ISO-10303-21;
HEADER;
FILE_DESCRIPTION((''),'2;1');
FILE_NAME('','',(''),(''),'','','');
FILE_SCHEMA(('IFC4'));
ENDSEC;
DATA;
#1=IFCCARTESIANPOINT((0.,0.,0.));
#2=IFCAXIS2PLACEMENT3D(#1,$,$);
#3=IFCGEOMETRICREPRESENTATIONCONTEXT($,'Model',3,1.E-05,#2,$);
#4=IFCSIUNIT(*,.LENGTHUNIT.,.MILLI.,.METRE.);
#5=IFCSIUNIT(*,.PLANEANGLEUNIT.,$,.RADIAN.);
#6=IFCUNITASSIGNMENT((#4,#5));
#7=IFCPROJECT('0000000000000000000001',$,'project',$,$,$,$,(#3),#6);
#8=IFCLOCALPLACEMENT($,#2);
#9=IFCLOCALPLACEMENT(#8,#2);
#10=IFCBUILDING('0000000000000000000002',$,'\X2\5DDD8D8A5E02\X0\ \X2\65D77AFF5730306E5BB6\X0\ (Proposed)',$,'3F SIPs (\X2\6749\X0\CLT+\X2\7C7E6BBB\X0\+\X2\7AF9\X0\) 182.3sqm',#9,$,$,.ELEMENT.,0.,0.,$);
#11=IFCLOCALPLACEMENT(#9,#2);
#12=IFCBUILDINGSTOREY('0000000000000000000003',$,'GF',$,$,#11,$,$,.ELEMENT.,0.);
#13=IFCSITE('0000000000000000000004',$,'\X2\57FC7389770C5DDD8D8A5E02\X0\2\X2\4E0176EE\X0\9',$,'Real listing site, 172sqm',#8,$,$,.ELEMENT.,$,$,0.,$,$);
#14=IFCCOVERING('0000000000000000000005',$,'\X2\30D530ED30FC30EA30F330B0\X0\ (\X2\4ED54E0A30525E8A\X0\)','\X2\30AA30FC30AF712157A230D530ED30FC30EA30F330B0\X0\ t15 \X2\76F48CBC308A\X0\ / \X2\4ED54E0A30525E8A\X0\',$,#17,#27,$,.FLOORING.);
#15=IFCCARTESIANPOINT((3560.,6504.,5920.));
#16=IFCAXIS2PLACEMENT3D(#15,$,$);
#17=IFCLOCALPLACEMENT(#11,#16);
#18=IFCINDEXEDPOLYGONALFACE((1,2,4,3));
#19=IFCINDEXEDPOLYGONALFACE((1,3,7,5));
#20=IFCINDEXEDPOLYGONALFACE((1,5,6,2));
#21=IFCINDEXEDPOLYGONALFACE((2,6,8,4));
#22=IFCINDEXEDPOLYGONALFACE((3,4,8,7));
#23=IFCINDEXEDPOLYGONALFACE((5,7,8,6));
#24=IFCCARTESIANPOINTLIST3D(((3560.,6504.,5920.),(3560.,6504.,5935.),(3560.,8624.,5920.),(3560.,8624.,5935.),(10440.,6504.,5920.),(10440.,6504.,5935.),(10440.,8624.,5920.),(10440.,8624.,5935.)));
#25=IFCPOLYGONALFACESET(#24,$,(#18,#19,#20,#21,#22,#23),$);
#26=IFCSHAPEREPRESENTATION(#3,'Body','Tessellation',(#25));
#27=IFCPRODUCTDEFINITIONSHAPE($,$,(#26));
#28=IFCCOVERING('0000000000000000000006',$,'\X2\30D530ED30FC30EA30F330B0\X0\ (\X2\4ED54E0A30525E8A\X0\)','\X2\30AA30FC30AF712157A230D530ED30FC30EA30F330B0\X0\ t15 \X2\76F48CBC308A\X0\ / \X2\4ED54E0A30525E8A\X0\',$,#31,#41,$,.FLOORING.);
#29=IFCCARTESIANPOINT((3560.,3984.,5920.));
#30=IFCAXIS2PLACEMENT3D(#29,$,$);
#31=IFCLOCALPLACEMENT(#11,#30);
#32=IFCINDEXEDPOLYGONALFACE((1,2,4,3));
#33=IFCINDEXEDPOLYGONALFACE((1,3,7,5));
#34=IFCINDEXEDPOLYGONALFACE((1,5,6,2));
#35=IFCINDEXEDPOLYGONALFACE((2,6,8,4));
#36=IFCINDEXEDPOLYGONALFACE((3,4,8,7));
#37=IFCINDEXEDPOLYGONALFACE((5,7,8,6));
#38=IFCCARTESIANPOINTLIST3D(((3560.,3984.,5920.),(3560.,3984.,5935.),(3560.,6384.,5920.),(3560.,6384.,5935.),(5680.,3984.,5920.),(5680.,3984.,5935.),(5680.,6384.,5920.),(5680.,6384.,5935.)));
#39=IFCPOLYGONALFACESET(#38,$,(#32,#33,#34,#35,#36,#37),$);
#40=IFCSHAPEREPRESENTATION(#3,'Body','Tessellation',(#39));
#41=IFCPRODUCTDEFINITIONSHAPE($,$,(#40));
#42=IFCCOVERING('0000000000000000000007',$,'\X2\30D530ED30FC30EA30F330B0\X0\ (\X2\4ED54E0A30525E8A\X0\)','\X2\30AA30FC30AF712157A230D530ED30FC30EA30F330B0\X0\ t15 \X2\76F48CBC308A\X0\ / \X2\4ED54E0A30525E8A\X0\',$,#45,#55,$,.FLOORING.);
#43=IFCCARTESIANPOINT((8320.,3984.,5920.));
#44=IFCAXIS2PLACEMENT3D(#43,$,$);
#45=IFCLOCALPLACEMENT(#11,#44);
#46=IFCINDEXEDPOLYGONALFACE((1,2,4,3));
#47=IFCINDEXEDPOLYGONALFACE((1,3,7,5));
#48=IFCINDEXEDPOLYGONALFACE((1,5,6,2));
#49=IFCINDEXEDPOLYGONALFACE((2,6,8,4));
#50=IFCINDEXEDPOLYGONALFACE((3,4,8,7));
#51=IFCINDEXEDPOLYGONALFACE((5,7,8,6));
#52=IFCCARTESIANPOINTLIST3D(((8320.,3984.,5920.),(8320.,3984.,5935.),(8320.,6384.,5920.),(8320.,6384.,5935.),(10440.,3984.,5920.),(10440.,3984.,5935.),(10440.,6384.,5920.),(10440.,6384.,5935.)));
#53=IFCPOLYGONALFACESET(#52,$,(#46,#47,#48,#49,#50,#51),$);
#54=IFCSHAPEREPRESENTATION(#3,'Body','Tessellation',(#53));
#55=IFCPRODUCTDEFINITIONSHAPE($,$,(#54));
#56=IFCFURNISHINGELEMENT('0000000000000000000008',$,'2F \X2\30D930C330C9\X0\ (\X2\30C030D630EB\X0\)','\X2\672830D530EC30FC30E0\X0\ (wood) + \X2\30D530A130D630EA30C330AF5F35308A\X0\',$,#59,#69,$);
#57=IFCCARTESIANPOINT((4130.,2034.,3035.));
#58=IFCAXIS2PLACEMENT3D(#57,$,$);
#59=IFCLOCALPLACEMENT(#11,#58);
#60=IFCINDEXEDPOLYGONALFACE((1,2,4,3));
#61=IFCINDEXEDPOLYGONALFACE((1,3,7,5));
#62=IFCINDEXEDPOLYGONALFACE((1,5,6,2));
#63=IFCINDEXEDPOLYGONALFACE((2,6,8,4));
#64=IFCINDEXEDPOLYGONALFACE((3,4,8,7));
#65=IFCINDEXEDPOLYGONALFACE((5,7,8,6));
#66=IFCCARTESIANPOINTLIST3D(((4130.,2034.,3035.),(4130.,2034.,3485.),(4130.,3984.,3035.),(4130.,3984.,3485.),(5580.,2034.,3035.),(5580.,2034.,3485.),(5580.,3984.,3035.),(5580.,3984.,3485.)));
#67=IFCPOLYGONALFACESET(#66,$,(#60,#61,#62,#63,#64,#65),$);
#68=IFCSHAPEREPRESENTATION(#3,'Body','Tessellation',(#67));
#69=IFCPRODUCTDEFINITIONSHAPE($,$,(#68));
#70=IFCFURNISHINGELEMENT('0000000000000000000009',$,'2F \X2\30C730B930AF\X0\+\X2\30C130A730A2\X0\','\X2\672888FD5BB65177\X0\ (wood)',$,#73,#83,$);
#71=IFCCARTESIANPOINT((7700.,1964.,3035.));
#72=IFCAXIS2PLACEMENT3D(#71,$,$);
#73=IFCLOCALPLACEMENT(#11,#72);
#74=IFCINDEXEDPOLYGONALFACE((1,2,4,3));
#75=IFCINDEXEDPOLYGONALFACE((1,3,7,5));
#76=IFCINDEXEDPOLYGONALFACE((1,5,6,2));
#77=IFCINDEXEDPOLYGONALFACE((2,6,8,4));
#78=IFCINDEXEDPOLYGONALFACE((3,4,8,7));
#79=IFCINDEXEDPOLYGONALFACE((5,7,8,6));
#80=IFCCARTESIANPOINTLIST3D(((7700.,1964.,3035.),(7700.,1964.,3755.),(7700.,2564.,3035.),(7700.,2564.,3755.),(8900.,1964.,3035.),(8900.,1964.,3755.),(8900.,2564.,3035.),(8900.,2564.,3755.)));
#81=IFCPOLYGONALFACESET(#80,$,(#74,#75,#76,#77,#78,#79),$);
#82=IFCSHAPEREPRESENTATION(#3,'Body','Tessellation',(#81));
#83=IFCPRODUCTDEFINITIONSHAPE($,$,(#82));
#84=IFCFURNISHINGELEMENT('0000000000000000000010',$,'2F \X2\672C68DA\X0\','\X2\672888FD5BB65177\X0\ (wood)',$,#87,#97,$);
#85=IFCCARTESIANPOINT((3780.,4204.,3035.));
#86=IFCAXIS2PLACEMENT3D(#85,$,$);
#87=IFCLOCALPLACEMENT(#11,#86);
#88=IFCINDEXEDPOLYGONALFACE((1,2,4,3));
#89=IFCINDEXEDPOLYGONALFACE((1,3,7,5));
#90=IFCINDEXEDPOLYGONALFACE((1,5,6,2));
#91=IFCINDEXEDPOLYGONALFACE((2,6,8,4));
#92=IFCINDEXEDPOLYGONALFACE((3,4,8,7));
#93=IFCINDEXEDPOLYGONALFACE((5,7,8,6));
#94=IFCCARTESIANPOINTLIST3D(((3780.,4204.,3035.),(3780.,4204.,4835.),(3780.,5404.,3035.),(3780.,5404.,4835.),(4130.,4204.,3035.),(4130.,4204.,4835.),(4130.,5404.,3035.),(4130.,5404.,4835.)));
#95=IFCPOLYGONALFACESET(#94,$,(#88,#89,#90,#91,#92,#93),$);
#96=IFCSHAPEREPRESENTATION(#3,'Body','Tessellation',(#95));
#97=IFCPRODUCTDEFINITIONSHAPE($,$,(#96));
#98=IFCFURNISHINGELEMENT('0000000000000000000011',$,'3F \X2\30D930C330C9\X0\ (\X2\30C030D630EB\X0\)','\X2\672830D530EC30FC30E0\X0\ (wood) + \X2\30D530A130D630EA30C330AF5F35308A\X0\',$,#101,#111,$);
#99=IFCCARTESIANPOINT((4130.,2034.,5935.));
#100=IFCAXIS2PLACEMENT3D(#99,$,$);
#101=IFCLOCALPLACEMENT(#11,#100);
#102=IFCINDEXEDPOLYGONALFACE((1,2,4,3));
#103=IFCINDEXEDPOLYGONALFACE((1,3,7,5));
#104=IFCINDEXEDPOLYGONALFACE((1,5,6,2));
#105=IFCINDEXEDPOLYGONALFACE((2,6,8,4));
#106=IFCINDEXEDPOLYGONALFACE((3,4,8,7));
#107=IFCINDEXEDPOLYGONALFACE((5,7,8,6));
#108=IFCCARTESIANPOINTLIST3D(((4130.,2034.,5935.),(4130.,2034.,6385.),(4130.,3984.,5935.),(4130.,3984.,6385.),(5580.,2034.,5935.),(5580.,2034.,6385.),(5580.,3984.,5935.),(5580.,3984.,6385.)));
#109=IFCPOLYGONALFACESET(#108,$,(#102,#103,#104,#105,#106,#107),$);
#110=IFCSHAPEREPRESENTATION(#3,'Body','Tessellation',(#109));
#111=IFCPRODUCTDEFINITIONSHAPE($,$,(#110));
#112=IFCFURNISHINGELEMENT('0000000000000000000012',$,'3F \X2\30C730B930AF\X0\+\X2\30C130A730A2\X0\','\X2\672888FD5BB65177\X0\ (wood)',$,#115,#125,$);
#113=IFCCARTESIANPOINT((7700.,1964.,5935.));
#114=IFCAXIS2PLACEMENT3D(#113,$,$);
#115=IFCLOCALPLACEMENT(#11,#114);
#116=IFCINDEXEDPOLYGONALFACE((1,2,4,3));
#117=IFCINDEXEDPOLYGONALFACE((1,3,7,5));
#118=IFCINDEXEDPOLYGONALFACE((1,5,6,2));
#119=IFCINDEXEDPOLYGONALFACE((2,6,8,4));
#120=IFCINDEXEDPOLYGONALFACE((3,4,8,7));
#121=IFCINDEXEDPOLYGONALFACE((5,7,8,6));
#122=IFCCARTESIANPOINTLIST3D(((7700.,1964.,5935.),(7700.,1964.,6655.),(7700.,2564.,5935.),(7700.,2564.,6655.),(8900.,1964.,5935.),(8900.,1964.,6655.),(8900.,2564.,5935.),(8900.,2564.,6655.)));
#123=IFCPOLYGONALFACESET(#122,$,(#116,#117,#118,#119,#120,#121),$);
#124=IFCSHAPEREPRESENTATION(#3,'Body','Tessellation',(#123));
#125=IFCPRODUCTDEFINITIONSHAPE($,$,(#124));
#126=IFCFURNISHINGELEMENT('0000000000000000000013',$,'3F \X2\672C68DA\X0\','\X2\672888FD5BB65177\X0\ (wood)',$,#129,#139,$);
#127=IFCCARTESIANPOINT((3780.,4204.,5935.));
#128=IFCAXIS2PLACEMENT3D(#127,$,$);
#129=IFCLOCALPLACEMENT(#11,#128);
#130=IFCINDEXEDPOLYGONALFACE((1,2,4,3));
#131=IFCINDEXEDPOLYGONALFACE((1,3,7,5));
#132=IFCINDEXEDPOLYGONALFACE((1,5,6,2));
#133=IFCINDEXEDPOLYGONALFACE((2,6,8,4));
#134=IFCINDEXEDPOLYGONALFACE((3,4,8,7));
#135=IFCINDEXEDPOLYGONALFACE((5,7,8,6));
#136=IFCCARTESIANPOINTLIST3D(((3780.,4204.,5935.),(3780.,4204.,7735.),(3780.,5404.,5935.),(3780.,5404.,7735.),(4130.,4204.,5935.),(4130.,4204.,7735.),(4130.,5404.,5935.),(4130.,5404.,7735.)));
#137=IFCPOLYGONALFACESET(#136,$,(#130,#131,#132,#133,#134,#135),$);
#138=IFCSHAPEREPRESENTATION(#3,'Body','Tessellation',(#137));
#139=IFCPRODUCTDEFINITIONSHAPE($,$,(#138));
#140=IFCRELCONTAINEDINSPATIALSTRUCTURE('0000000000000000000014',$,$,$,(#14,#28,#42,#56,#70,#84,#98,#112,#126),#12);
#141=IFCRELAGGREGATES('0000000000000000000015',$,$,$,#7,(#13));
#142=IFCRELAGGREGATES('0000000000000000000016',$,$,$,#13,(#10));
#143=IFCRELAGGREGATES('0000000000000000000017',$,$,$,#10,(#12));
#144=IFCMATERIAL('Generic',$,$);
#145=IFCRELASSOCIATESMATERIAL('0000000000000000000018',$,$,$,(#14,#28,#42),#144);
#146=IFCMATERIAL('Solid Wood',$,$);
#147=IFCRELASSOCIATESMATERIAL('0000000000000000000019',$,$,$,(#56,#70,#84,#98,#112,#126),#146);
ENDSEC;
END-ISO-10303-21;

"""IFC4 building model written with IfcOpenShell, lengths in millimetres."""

from ifc_helpers import new_model, si_unit, frame, frame_2d, origin, place, context, project, spatial, rectangle, extrude, material, element, save


model = new_model("IFC4")

# Units and contexts
model_context = context("Model", 3, precision=1e-05, world=origin())
ifc_project = project(units=[si_unit("LENGTHUNIT", "METRE", prefix="MILLI"), si_unit("PLANEANGLEUNIT", "RADIAN")], contexts=[model_context])

# Site, building, storey
site_placement = place(None, origin())
site = spatial("IfcSite", under=ifc_project, at=site_placement, Name="埼玉県川越市2丁目9", ObjectType="Real listing site, 172sqm", CompositionType="ELEMENT", RefElevation=0.0)
building_placement = place(site_placement, origin())
building = spatial("IfcBuilding", under=site, at=building_placement, Name="川越市 旗竿地の家 (Proposed)", ObjectType="3F SIPs (杉CLT+籾殻+竹) 182.3sqm", CompositionType="ELEMENT", ElevationOfRefHeight=0.0, ElevationOfTerrain=0.0)
storey_placement = place(building_placement, origin())
storey = spatial("IfcBuildingStorey", under=building, at=storey_placement, Name="GF", CompositionType="ELEMENT", Elevation=0.0)

# Shared definitions
ifc_material_1 = material(Name="Solid Wood")

# Shared definitions
ifc_material_2 = material(Name="Generic")

# Coverings
covering_1_placement = place(storey_placement, frame((3560.0, 6504.0, 5920.0)))
element("IfcCovering", 1, at=covering_1_placement, inside=storey, material=ifc_material_2, Name="フローリング (仕上げ床)", Description="オーク無垢フローリング t15 直貼り / 仕上げ床", PredefinedType="FLOORING", context=model_context, shape_type="SweptSolid", body=[
    extrude(rectangle(XDim=6880.0, YDim=2120.0, at=frame_2d((3440.0, 1060.0))), frame((3560.0, 6504.0, 5920.0)), (0.0, 0.0, 1.0), 15.0),
])
covering_2_placement = place(storey_placement, frame((3560.0, 3984.0, 5920.0)))
element("IfcCovering", 2, at=covering_2_placement, inside=storey, material=ifc_material_2, Name="フローリング (仕上げ床)", Description="オーク無垢フローリング t15 直貼り / 仕上げ床", PredefinedType="FLOORING", context=model_context, shape_type="SweptSolid", body=[
    extrude(rectangle(XDim=2120.0, YDim=2400.0, at=frame_2d((1060.0, 1200.0))), frame((3560.0, 3984.0, 5920.0)), (0.0, 0.0, 1.0), 15.0),
])
covering_3_placement = place(storey_placement, frame((8320.0, 3984.0, 5920.0)))
element("IfcCovering", 3, at=covering_3_placement, inside=storey, material=ifc_material_2, Name="フローリング (仕上げ床)", Description="オーク無垢フローリング t15 直貼り / 仕上げ床", PredefinedType="FLOORING", context=model_context, shape_type="SweptSolid", body=[
    extrude(rectangle(XDim=2120.0, YDim=2400.0, at=frame_2d((1060.0, 1200.0))), frame((8320.0, 3984.0, 5920.0)), (0.0, 0.0, 1.0), 15.0),
])

# Furnishing elements
furnishing_1_placement = place(storey_placement, frame((4130.0, 2034.0, 3035.0)))
element("IfcFurnishingElement", 4, at=furnishing_1_placement, inside=storey, material=ifc_material_1, Name="2F ベッド (ダブル)", Description="木フレーム (wood) + ファブリック張り", context=model_context, shape_type="SweptSolid", body=[
    extrude(rectangle(XDim=1450.0, YDim=1950.0, at=frame_2d((725.0, 975.0))), frame((4130.0, 2034.0, 3035.0)), (0.0, 0.0, 1.0), 450.0),
])
furnishing_2_placement = place(storey_placement, frame((7700.0, 1964.0, 3035.0)))
element("IfcFurnishingElement", 5, at=furnishing_2_placement, inside=storey, material=ifc_material_1, Name="2F デスク+チェア", Description="木製家具 (wood)", context=model_context, shape_type="SweptSolid", body=[
    extrude(rectangle(XDim=1200.0, YDim=600.0, at=frame_2d((600.0, 300.0))), frame((7700.0, 1964.0, 3035.0)), (0.0, 0.0, 1.0), 720.0),
])
furnishing_3_placement = place(storey_placement, frame((3780.0, 4204.0, 3035.0)))
element("IfcFurnishingElement", 6, at=furnishing_3_placement, inside=storey, material=ifc_material_1, Name="2F 本棚", Description="木製家具 (wood)", context=model_context, shape_type="SweptSolid", body=[
    extrude(rectangle(XDim=350.0, YDim=1200.0, at=frame_2d((175.0, 600.0))), frame((3780.0, 4204.0, 3035.0)), (0.0, 0.0, 1.0), 1800.0),
])
furnishing_4_placement = place(storey_placement, frame((4130.0, 2034.0, 5935.0)))
element("IfcFurnishingElement", 7, at=furnishing_4_placement, inside=storey, material=ifc_material_1, Name="3F ベッド (ダブル)", Description="木フレーム (wood) + ファブリック張り", context=model_context, shape_type="SweptSolid", body=[
    extrude(rectangle(XDim=1450.0, YDim=1950.0, at=frame_2d((725.0, 975.0))), frame((4130.0, 2034.0, 5935.0)), (0.0, 0.0, 1.0), 450.0),
])
furnishing_5_placement = place(storey_placement, frame((7700.0, 1964.0, 5935.0)))
element("IfcFurnishingElement", 8, at=furnishing_5_placement, inside=storey, material=ifc_material_1, Name="3F デスク+チェア", Description="木製家具 (wood)", context=model_context, shape_type="SweptSolid", body=[
    extrude(rectangle(XDim=1200.0, YDim=600.0, at=frame_2d((600.0, 300.0))), frame((7700.0, 1964.0, 5935.0)), (0.0, 0.0, 1.0), 720.0),
])
furnishing_6_placement = place(storey_placement, frame((3780.0, 4204.0, 5935.0)))
element("IfcFurnishingElement", 9, at=furnishing_6_placement, inside=storey, material=ifc_material_1, Name="3F 本棚", Description="木製家具 (wood)", context=model_context, shape_type="SweptSolid", body=[
    extrude(rectangle(XDim=350.0, YDim=1200.0, at=frame_2d((175.0, 600.0))), frame((3780.0, 4204.0, 5935.0)), (0.0, 0.0, 1.0), 1800.0),
])

save(model, "model.ifc")
